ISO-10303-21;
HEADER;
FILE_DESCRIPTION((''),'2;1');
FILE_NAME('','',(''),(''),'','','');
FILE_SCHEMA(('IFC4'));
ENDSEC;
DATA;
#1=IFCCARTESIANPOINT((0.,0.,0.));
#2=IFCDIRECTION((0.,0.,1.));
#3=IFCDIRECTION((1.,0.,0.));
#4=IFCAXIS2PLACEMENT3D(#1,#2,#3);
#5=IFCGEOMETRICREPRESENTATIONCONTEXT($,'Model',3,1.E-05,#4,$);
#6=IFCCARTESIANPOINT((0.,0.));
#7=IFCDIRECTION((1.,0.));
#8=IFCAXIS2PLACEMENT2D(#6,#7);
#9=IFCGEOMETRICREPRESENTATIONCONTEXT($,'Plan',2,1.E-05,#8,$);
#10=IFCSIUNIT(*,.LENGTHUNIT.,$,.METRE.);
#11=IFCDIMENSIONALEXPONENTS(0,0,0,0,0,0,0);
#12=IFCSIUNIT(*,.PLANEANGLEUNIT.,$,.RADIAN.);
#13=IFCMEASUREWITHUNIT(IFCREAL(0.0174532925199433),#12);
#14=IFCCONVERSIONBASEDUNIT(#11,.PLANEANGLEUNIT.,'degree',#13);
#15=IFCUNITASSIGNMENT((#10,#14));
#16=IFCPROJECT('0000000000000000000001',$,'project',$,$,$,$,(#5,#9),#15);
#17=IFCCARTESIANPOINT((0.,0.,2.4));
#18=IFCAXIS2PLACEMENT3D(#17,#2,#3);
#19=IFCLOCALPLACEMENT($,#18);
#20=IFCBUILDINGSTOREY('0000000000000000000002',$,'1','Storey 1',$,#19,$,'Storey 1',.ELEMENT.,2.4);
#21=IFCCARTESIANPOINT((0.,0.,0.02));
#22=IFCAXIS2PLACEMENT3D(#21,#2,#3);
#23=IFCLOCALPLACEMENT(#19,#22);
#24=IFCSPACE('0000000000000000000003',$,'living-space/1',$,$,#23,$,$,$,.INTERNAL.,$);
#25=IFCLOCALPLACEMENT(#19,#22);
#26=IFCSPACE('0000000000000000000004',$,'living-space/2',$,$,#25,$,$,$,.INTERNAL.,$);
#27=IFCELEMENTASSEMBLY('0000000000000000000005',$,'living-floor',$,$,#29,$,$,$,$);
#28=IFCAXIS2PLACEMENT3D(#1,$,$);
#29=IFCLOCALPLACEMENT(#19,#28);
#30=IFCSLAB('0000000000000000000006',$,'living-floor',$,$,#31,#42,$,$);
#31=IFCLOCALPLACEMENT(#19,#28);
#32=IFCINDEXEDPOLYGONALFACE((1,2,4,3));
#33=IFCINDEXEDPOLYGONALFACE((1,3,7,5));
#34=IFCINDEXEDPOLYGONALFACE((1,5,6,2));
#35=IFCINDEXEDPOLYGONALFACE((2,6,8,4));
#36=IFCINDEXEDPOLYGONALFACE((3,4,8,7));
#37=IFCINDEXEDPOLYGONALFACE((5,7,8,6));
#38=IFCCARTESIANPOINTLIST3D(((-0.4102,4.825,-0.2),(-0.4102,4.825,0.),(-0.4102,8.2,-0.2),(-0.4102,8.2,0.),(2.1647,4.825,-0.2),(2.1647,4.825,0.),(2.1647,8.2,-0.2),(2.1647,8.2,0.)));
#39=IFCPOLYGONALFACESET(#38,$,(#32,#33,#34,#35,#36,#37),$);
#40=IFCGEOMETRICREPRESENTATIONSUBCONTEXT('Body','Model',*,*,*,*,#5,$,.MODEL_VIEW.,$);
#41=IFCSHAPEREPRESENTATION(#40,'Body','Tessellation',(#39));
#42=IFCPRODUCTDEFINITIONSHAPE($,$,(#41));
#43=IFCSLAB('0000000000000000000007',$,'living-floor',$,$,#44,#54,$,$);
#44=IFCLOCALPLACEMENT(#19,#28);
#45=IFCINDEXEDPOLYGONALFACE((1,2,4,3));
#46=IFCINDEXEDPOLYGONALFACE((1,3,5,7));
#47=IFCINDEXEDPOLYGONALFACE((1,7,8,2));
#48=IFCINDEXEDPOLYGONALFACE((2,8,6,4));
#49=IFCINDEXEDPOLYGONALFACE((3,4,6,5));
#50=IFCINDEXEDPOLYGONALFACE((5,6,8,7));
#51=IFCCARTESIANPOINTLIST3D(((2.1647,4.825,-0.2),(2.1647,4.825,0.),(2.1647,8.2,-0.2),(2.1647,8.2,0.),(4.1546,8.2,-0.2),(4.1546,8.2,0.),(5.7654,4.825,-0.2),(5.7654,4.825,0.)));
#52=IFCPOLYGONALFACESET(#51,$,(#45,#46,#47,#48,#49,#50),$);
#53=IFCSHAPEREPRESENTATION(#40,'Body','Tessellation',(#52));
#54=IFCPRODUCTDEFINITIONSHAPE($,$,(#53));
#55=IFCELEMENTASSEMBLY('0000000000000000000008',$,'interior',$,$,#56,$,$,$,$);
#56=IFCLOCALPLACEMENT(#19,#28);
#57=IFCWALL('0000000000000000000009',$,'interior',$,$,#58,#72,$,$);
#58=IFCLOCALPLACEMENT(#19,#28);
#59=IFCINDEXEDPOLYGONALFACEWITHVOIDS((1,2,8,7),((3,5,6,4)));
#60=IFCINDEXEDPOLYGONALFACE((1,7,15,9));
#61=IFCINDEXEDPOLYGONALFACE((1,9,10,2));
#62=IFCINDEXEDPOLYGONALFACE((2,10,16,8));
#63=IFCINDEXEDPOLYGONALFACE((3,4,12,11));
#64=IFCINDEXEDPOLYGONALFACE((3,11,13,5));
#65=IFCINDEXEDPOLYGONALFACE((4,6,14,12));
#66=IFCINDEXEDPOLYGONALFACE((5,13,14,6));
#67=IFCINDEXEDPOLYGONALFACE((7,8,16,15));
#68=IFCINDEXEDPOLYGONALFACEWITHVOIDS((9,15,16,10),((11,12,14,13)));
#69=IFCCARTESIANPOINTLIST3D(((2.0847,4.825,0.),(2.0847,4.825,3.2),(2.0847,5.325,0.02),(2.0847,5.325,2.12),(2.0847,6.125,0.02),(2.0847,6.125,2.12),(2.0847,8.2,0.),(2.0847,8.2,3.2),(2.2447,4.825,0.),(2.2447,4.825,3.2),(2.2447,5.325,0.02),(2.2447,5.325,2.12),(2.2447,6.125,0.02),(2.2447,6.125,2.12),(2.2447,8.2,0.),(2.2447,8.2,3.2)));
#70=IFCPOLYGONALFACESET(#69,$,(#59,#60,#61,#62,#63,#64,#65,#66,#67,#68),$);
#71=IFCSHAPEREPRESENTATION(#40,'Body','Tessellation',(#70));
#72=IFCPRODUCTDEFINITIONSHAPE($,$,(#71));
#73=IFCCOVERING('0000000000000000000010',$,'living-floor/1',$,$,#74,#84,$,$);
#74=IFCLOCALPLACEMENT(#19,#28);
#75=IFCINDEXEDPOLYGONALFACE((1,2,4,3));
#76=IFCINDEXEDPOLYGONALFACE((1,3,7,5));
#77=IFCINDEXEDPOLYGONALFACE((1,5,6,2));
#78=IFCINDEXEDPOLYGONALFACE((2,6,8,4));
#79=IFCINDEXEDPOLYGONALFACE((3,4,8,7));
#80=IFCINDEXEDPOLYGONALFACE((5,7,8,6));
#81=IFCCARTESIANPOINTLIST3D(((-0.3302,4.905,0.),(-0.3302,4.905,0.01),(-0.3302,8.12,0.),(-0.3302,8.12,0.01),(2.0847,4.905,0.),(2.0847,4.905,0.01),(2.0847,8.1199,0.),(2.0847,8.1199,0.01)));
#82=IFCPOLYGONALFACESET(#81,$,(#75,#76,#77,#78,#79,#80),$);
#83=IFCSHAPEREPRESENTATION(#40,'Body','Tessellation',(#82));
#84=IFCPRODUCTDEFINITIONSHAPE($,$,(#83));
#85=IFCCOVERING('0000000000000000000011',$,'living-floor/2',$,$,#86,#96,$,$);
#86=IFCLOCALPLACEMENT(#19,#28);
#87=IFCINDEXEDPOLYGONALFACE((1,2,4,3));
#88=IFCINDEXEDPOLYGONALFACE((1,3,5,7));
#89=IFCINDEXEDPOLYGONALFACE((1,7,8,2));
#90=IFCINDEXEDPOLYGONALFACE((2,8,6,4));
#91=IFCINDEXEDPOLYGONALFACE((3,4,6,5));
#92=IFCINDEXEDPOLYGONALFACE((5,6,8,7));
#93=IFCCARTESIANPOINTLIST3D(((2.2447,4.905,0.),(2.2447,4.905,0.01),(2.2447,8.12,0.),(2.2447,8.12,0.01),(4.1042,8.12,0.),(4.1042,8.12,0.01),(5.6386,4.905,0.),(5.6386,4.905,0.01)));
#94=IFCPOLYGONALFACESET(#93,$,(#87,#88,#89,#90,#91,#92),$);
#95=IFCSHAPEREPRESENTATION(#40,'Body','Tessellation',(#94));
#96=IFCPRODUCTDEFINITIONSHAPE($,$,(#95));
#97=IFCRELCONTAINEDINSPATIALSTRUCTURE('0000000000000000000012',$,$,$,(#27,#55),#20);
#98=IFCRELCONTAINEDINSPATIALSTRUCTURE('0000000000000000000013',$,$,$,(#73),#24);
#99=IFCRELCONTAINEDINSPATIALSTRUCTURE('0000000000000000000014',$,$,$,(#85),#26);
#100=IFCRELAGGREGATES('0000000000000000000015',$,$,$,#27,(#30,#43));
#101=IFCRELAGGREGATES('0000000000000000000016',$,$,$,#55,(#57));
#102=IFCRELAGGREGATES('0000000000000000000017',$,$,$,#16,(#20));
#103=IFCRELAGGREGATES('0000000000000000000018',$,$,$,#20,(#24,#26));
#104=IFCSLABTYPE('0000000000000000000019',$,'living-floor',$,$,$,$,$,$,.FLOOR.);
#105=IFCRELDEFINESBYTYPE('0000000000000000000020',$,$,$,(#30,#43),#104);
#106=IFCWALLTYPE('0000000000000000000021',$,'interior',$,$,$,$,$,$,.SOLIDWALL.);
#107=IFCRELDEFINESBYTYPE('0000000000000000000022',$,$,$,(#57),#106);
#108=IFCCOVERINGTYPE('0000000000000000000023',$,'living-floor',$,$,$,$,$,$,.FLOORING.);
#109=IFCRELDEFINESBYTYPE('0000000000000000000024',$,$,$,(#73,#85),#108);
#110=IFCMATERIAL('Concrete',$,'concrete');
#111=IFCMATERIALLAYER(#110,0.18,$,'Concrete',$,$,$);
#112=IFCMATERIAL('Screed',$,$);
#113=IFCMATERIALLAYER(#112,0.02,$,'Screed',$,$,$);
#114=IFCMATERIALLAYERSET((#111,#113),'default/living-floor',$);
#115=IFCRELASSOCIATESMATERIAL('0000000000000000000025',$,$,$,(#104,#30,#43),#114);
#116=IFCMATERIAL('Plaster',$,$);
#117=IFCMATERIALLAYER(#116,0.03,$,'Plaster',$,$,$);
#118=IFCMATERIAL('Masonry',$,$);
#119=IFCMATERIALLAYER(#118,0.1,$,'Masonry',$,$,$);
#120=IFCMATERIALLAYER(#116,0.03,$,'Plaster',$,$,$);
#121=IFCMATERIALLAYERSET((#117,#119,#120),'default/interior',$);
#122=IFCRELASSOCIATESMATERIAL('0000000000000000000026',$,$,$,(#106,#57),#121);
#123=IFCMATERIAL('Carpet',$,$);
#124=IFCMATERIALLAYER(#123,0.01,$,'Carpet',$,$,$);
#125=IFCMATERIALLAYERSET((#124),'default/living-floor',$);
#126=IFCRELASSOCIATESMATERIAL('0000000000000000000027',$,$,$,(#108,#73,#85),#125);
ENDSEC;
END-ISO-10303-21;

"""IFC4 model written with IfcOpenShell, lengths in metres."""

from ifc_helpers import new_model, entity, si_unit, converted_unit, frame, origin, origin_with_axes, origin_2d_with_axis, place, context, subcontext, project, spatial, polyline, outline, extrude, material, layer, layer_set, layer_usage, type_object, element, aggregate, save


model = new_model("IFC4")

# Units and contexts
model_context = context("Model", 3, precision=1e-05, world=origin_with_axes())
plan_context = context("Plan", 2, precision=1e-05, world=origin_2d_with_axis())
body_context = subcontext(model_context, "Body", "Model", "MODEL_VIEW")
ifc_project = project(units=[si_unit("LENGTHUNIT", "METRE"), converted_unit("PLANEANGLEUNIT", "degree", entity("IfcReal", 0.0174532925199433), si_unit("PLANEANGLEUNIT", "RADIAN"), dimensions=[0, 0, 0, 0, 0, 0, 0])], contexts=[model_context, plan_context])

# Storey
storey_placement = place(None, frame((0.0, 0.0, 2.4), z_axis=(0.0, 0.0, 1.0), x_axis=(1.0, 0.0, 0.0)))
storey = spatial("IfcBuildingStorey", under=ifc_project, at=storey_placement, Name="1", Description="Storey 1", LongName="Storey 1", CompositionType="ELEMENT", Elevation=2.4)

# Element assembly, slabs
assembly_1_placement = place(storey_placement, frame((0.0, 0.0, -2.4), z_axis=(0.0, 0.0, 1.0), x_axis=(1.0, 0.0, 0.0)))
assembly_1 = element("IfcElementAssembly", 1, at=assembly_1_placement, inside=storey, Name="living-floor")
ifc_material_1 = material(Name="Concrete", Category="concrete")
ifc_layer_1 = layer(ifc_material_1, 0.18, Name="Concrete")
ifc_material_2 = material(Name="Screed")
ifc_layer_2 = layer(ifc_material_2, 0.02, Name="Screed")
ifc_layer_set_1 = layer_set([ifc_layer_1, ifc_layer_2], Name="default/living-floor")
ifc_layer_usage_1 = layer_usage(ifc_layer_set_1, "AXIS3", "POSITIVE", 0.0)
slab_type = type_object("IfcSlabType", Name="living-floor", PredefinedType="FLOOR", material=ifc_layer_set_1)
slab_1_placement = place(assembly_1_placement, frame((2.1647, 8.2, 2.2), z_axis=(0.0, 0.0, 1.0), x_axis=(1.0, 0.0, 0.0)))
slab_1 = element("IfcSlab", 2, at=slab_1_placement, type_object=slab_type, material=ifc_layer_usage_1, Name="living-floor", context=body_context, shape_type="SweptSolid", body=[
    extrude(outline(polyline([(0.0, 0.0), (-2.5749, 0.0), (-2.5749, -3.375), (0.0, -3.375), (0.0, 0.0)])), origin(), (0.0, 0.0, 1.0), 0.2),
])
ifc_layer_usage_2 = layer_usage(ifc_layer_set_1, "AXIS3", "POSITIVE", 0.0)
slab_2_placement = place(assembly_1_placement, frame((2.1647, 8.2, 2.2), z_axis=(0.0, 0.0, 1.0), x_axis=(1.0, 0.0, 0.0)))
slab_2 = element("IfcSlab", 3, at=slab_2_placement, type_object=slab_type, material=ifc_layer_usage_2, Name="living-floor", context=body_context, shape_type="SweptSolid", body=[
    extrude(outline(polyline([(0.0, 0.0), (0.0, -3.375), (3.6007, -3.375), (1.99, 0.0), (0.0, 0.0)])), origin(), (0.0, 0.0, 1.0), 0.2),
])
aggregate(assembly_1, [slab_1, slab_2])

# Element assembly, wall, opening
assembly_2_placement = place(storey_placement, frame((2.1647, 4.825, 0.0), z_axis=(0.0, 0.0, 1.0), x_axis=(0.0, 1.0, 0.0)))
assembly_2 = element("IfcElementAssembly", 4, at=assembly_2_placement, inside=storey, Name="interior")
ifc_material_3 = material(Name="Plaster")
ifc_layer_3 = layer(ifc_material_3, 0.03, Name="Plaster")
ifc_material_4 = material(Name="Masonry")
ifc_layer_4 = layer(ifc_material_4, 0.1, Name="Masonry")
ifc_layer_5 = layer(ifc_material_3, 0.03, Name="Plaster")
ifc_layer_set_2 = layer_set([ifc_layer_3, ifc_layer_4, ifc_layer_5], Name="default/interior")
ifc_layer_usage_3 = layer_usage(ifc_layer_set_2, "AXIS2", "POSITIVE", -0.08)
wall_type_1 = type_object("IfcWallType", Name="interior", PredefinedType="SOLIDWALL", material=ifc_layer_set_2)
wall_1_placement = place(assembly_2_placement, origin_with_axes())
wall_1 = element("IfcWall", 5, at=wall_1_placement, type_object=wall_type_1, material=ifc_layer_usage_3, Name="interior", context=body_context, shape_type="SweptSolid", body=[
    extrude(outline(polyline([(0.0, 0.08), (0.0, -0.08), (3.375, -0.08), (3.375, 0.08), (0.0, 0.08)])), origin(), (0.0, 0.0, 1.0), 3.2),
])
opening_placement = place(wall_1_placement, frame((0.5, -0.08, 0.02), z_axis=(0.0, 0.0, 1.0), x_axis=(1.0, 0.0, 0.0)))
element("IfcOpeningElement", 6, at=opening_placement, cuts=wall_1, PredefinedType="OPENING", context=body_context, shape_type="SweptSolid", body=[
    extrude(outline(polyline([(0.0, 0.0), (0.8, 0.0), (0.8, 2.1), (0.0, 2.1), (0.0, 0.0)])), frame((0.0, -0.02, 0.0), z_axis=(0.0, -1.0, 0.0), x_axis=(1.0, 0.0, 0.0)), (0.0, 0.0, -1.0), 0.2),
])
aggregate(assembly_2, [wall_1])

# Shared definitions
space_1_placement = place(storey_placement, frame((0.0, 0.0, 0.02), z_axis=(0.0, 0.0, 1.0), x_axis=(1.0, 0.0, 0.0)))
space_1 = spatial("IfcSpace", under=storey, at=space_1_placement, Name="living-space/1", PredefinedType="INTERNAL")

# Covering
ifc_material_5 = material(Name="Carpet")
ifc_layer_6 = layer(ifc_material_5, 0.01, Name="Carpet")
ifc_layer_set_3 = layer_set([ifc_layer_6], Name="default/living-floor")
ifc_layer_usage_4 = layer_usage(ifc_layer_set_3, "AXIS2", "POSITIVE", 0.0)
covering_type = type_object("IfcCoveringType", Name="living-floor", PredefinedType="FLOORING", material=ifc_layer_set_3)
covering_1_placement = place(space_1_placement, frame((0.0, 0.0, -0.02), z_axis=(0.0, 0.0, 1.0), x_axis=(1.0, 0.0, 0.0)))
element("IfcCovering", 7, at=covering_1_placement, inside=space_1, type_object=covering_type, material=ifc_layer_usage_4, Name="living-floor/1", context=body_context, shape_type="SweptSolid", body=[
    extrude(outline(polyline([(-0.3302, 4.905), (2.0847, 4.905), (2.0847, 8.1199), (-0.3302, 8.12), (-0.3302, 4.905)])), origin_with_axes(), (0.0, 0.0, 1.0), 0.01),
])

# Shared definitions
space_2_placement = place(storey_placement, frame((0.0, 0.0, 0.02), z_axis=(0.0, 0.0, 1.0), x_axis=(1.0, 0.0, 0.0)))
space_2 = spatial("IfcSpace", under=storey, at=space_2_placement, Name="living-space/2", PredefinedType="INTERNAL")

# Covering
ifc_layer_usage_5 = layer_usage(ifc_layer_set_3, "AXIS2", "POSITIVE", 0.0)
covering_2_placement = place(space_2_placement, frame((0.0, 0.0, -0.02), z_axis=(0.0, 0.0, 1.0), x_axis=(1.0, 0.0, 0.0)))
element("IfcCovering", 8, at=covering_2_placement, inside=space_2, type_object=covering_type, material=ifc_layer_usage_5, Name="living-floor/2", context=body_context, shape_type="SweptSolid", body=[
    extrude(outline(polyline([(5.6386, 4.905), (4.1042, 8.12), (2.2447, 8.12), (2.2447, 4.905), (5.6386, 4.905)])), origin_with_axes(), (0.0, 0.0, 1.0), 0.01),
])

save(model, "model.ifc")
